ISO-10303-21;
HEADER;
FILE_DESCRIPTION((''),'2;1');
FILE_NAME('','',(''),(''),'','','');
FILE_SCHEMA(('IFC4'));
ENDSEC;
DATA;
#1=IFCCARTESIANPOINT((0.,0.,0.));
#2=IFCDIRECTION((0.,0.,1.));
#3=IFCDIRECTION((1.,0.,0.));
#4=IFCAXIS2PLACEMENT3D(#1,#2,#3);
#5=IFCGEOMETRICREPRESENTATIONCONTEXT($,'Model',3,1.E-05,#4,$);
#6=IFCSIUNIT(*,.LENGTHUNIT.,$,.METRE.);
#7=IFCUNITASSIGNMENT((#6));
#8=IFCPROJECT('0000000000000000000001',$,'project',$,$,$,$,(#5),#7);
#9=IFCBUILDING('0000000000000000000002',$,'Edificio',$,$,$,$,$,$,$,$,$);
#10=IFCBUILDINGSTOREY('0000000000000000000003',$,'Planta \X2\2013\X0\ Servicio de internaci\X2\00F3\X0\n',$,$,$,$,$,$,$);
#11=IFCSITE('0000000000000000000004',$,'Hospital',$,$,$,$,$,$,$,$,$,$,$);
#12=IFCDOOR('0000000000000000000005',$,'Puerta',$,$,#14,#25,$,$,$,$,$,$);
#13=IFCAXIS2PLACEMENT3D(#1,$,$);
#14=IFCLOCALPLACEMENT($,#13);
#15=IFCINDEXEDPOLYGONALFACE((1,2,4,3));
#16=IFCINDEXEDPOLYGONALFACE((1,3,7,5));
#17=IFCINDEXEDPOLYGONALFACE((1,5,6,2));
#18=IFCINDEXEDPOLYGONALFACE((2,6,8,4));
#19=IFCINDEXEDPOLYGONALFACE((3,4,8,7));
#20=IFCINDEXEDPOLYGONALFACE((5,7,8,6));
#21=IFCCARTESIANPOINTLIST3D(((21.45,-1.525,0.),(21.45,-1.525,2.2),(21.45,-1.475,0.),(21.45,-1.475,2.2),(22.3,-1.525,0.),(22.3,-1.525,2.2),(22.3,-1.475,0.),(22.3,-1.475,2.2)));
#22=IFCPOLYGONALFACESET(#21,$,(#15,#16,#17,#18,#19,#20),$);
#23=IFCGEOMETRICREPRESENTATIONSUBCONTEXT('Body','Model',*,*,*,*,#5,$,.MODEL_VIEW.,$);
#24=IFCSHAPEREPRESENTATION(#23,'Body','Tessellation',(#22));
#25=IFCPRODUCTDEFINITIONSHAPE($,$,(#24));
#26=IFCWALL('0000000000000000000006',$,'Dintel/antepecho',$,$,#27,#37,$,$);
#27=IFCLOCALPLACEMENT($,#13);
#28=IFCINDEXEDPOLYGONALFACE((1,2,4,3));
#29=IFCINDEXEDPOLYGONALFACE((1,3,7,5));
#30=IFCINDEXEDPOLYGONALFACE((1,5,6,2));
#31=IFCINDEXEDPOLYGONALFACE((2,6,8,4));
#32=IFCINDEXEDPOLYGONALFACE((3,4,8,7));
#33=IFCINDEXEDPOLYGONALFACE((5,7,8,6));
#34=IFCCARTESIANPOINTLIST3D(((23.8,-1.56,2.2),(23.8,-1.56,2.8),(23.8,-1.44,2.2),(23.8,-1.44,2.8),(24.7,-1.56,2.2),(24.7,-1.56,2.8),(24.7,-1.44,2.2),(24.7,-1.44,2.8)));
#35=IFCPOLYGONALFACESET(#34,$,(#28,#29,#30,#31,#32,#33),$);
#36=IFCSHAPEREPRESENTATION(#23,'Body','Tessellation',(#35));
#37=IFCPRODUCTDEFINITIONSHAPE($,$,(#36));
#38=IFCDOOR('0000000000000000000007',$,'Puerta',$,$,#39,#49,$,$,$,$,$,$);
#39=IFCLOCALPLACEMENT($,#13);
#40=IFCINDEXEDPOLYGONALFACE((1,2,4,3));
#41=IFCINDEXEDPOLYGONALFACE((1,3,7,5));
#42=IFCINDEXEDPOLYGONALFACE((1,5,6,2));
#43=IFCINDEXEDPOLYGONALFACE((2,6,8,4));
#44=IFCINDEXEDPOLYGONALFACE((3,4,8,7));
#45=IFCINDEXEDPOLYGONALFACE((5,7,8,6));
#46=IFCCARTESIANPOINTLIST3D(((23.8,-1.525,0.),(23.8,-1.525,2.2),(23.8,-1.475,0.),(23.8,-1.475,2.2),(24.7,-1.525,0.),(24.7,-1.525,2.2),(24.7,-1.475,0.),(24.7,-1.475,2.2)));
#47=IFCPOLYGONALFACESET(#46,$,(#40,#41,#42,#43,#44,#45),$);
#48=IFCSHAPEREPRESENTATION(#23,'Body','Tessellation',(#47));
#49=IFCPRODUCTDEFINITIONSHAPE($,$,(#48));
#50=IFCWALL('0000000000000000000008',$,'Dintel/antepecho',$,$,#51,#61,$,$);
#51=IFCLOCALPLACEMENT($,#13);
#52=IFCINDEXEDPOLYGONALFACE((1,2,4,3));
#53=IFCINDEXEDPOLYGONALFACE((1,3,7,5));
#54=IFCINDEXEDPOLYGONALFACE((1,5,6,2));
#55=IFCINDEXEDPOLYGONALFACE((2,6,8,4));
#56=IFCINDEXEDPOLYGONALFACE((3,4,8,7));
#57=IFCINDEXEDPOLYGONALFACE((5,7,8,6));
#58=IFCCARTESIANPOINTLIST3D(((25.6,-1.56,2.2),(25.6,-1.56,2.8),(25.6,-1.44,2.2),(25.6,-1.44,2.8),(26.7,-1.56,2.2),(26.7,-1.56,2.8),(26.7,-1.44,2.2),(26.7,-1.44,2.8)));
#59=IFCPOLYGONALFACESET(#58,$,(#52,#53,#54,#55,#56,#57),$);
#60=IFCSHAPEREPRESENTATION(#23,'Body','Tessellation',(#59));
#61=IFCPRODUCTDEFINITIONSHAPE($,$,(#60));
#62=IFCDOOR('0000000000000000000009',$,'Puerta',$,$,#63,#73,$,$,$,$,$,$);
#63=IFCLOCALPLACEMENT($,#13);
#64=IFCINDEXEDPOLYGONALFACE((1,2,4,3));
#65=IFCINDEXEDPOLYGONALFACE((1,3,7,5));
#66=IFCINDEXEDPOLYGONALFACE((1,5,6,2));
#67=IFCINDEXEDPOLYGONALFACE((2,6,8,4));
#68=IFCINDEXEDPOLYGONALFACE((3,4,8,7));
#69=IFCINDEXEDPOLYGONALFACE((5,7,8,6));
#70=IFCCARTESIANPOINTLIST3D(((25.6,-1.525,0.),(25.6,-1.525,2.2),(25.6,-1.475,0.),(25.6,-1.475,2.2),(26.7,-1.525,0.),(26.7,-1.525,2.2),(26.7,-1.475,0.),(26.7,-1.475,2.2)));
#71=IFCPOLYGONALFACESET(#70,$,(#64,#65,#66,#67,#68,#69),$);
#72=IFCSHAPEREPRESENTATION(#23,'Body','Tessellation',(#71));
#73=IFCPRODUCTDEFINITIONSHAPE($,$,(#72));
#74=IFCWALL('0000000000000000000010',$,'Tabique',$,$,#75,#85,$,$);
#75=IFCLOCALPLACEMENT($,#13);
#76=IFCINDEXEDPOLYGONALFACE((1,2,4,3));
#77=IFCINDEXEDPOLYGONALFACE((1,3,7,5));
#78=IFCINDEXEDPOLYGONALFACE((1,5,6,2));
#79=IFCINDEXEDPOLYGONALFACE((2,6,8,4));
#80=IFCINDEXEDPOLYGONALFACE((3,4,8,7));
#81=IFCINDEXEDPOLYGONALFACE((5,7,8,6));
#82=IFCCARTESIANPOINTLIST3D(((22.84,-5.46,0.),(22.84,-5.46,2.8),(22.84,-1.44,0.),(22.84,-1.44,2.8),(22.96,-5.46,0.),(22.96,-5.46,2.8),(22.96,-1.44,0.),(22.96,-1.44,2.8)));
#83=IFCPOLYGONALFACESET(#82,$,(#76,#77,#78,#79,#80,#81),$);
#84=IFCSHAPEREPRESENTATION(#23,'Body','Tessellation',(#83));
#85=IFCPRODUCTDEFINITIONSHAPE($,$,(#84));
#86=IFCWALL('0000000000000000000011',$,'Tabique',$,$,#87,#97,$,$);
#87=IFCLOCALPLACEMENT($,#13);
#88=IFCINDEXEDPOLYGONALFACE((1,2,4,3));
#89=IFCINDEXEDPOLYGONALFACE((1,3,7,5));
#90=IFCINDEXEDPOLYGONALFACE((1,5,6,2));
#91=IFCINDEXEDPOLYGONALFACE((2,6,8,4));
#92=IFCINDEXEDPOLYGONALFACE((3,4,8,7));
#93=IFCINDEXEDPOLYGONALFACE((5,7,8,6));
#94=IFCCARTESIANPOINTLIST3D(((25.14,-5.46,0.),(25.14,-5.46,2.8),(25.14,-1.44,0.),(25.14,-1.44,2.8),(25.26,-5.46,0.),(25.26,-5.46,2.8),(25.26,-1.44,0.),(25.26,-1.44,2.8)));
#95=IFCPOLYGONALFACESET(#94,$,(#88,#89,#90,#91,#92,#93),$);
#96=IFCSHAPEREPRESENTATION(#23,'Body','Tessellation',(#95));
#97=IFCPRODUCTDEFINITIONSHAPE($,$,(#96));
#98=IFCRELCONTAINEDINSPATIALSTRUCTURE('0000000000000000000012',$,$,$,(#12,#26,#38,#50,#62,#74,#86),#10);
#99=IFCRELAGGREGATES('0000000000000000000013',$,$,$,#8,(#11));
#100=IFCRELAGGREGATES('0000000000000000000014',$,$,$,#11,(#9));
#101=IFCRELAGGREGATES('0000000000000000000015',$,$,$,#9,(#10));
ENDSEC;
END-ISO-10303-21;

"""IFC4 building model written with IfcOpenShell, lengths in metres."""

from ifc_helpers import new_model, si_unit, frame, origin_with_axes, context, subcontext, project, spatial, line, indexed_curve, outline, extrude, element, save


model = new_model("IFC4")

# Units and contexts
model_context = context("Model", 3, precision=1e-05, world=origin_with_axes())
body_context = subcontext(model_context, "Body", "Model", "MODEL_VIEW")
ifc_project = project(units=[si_unit("LENGTHUNIT", "METRE")], contexts=[model_context])

# Site, building, storey
site = spatial("IfcSite", under=ifc_project, Name="Hospital")
building = spatial("IfcBuilding", under=site, Name="Edificio")
storey = spatial("IfcBuildingStorey", under=building, Name="Planta – Servicio de internación")

# Door
element("IfcDoor", 1, inside=storey, Name="Puerta", context=body_context, shape_type="SweptSolid", body=[
    extrude(outline(indexed_curve([(0.0, 0.0), (0.85, 0.0), (0.85, 0.05), (0.0, 0.05)], segments=[line(1, 2, 3, 4, 1)])), frame((21.45, -1.525, 0.0), z_axis=(0.0, 0.0, 1.0), x_axis=(1.0, 0.0, 0.0)), (0.0, 0.0, 1.0), 2.2),
])

# Wall
element("IfcWall", 2, inside=storey, Name="Dintel/antepecho", context=body_context, shape_type="SweptSolid", body=[
    extrude(outline(indexed_curve([(0.0, 0.0), (0.9, 0.0), (0.9, 0.12), (0.0, 0.12)], segments=[line(1, 2, 3, 4, 1)])), frame((23.8, -1.56, 2.2), z_axis=(0.0, 0.0, 1.0), x_axis=(1.0, 0.0, 0.0)), (0.0, 0.0, 1.0), 0.6),
])

# Door
element("IfcDoor", 3, inside=storey, Name="Puerta", context=body_context, shape_type="SweptSolid", body=[
    extrude(outline(indexed_curve([(0.0, 0.0), (0.9, 0.0), (0.9, 0.05), (0.0, 0.05)], segments=[line(1, 2, 3, 4, 1)])), frame((23.8, -1.525, 0.0), z_axis=(0.0, 0.0, 1.0), x_axis=(1.0, 0.0, 0.0)), (0.0, 0.0, 1.0), 2.2),
])

# Wall
element("IfcWall", 4, inside=storey, Name="Dintel/antepecho", context=body_context, shape_type="SweptSolid", body=[
    extrude(outline(indexed_curve([(0.0, 0.0), (1.1, 0.0), (1.1, 0.12), (0.0, 0.12)], segments=[line(1, 2, 3, 4, 1)])), frame((25.6, -1.56, 2.2), z_axis=(0.0, 0.0, 1.0), x_axis=(1.0, 0.0, 0.0)), (0.0, 0.0, 1.0), 0.6),
])

# Door
element("IfcDoor", 5, inside=storey, Name="Puerta", context=body_context, shape_type="SweptSolid", body=[
    extrude(outline(indexed_curve([(0.0, 0.0), (1.1, 0.0), (1.1, 0.05), (0.0, 0.05)], segments=[line(1, 2, 3, 4, 1)])), frame((25.6, -1.525, 0.0), z_axis=(0.0, 0.0, 1.0), x_axis=(1.0, 0.0, 0.0)), (0.0, 0.0, 1.0), 2.2),
])

# Walls
element("IfcWall", 6, inside=storey, Name="Tabique", context=body_context, shape_type="SweptSolid", body=[
    extrude(outline(indexed_curve([(0.0, 0.0), (0.12, 0.0), (0.12, 4.02), (0.0, 4.02)], segments=[line(1, 2, 3, 4, 1)])), frame((22.84, -5.46, 0.0), z_axis=(0.0, 0.0, 1.0), x_axis=(1.0, 0.0, 0.0)), (0.0, 0.0, 1.0), 2.8),
])
element("IfcWall", 7, inside=storey, Name="Tabique", context=body_context, shape_type="SweptSolid", body=[
    extrude(outline(indexed_curve([(0.0, 0.0), (0.12, 0.0), (0.12, 4.02), (0.0, 4.02)], segments=[line(1, 2, 3, 4, 1)])), frame((25.14, -5.46, 0.0), z_axis=(0.0, 0.0, 1.0), x_axis=(1.0, 0.0, 0.0)), (0.0, 0.0, 1.0), 2.8),
])

save(model, "model.ifc")
